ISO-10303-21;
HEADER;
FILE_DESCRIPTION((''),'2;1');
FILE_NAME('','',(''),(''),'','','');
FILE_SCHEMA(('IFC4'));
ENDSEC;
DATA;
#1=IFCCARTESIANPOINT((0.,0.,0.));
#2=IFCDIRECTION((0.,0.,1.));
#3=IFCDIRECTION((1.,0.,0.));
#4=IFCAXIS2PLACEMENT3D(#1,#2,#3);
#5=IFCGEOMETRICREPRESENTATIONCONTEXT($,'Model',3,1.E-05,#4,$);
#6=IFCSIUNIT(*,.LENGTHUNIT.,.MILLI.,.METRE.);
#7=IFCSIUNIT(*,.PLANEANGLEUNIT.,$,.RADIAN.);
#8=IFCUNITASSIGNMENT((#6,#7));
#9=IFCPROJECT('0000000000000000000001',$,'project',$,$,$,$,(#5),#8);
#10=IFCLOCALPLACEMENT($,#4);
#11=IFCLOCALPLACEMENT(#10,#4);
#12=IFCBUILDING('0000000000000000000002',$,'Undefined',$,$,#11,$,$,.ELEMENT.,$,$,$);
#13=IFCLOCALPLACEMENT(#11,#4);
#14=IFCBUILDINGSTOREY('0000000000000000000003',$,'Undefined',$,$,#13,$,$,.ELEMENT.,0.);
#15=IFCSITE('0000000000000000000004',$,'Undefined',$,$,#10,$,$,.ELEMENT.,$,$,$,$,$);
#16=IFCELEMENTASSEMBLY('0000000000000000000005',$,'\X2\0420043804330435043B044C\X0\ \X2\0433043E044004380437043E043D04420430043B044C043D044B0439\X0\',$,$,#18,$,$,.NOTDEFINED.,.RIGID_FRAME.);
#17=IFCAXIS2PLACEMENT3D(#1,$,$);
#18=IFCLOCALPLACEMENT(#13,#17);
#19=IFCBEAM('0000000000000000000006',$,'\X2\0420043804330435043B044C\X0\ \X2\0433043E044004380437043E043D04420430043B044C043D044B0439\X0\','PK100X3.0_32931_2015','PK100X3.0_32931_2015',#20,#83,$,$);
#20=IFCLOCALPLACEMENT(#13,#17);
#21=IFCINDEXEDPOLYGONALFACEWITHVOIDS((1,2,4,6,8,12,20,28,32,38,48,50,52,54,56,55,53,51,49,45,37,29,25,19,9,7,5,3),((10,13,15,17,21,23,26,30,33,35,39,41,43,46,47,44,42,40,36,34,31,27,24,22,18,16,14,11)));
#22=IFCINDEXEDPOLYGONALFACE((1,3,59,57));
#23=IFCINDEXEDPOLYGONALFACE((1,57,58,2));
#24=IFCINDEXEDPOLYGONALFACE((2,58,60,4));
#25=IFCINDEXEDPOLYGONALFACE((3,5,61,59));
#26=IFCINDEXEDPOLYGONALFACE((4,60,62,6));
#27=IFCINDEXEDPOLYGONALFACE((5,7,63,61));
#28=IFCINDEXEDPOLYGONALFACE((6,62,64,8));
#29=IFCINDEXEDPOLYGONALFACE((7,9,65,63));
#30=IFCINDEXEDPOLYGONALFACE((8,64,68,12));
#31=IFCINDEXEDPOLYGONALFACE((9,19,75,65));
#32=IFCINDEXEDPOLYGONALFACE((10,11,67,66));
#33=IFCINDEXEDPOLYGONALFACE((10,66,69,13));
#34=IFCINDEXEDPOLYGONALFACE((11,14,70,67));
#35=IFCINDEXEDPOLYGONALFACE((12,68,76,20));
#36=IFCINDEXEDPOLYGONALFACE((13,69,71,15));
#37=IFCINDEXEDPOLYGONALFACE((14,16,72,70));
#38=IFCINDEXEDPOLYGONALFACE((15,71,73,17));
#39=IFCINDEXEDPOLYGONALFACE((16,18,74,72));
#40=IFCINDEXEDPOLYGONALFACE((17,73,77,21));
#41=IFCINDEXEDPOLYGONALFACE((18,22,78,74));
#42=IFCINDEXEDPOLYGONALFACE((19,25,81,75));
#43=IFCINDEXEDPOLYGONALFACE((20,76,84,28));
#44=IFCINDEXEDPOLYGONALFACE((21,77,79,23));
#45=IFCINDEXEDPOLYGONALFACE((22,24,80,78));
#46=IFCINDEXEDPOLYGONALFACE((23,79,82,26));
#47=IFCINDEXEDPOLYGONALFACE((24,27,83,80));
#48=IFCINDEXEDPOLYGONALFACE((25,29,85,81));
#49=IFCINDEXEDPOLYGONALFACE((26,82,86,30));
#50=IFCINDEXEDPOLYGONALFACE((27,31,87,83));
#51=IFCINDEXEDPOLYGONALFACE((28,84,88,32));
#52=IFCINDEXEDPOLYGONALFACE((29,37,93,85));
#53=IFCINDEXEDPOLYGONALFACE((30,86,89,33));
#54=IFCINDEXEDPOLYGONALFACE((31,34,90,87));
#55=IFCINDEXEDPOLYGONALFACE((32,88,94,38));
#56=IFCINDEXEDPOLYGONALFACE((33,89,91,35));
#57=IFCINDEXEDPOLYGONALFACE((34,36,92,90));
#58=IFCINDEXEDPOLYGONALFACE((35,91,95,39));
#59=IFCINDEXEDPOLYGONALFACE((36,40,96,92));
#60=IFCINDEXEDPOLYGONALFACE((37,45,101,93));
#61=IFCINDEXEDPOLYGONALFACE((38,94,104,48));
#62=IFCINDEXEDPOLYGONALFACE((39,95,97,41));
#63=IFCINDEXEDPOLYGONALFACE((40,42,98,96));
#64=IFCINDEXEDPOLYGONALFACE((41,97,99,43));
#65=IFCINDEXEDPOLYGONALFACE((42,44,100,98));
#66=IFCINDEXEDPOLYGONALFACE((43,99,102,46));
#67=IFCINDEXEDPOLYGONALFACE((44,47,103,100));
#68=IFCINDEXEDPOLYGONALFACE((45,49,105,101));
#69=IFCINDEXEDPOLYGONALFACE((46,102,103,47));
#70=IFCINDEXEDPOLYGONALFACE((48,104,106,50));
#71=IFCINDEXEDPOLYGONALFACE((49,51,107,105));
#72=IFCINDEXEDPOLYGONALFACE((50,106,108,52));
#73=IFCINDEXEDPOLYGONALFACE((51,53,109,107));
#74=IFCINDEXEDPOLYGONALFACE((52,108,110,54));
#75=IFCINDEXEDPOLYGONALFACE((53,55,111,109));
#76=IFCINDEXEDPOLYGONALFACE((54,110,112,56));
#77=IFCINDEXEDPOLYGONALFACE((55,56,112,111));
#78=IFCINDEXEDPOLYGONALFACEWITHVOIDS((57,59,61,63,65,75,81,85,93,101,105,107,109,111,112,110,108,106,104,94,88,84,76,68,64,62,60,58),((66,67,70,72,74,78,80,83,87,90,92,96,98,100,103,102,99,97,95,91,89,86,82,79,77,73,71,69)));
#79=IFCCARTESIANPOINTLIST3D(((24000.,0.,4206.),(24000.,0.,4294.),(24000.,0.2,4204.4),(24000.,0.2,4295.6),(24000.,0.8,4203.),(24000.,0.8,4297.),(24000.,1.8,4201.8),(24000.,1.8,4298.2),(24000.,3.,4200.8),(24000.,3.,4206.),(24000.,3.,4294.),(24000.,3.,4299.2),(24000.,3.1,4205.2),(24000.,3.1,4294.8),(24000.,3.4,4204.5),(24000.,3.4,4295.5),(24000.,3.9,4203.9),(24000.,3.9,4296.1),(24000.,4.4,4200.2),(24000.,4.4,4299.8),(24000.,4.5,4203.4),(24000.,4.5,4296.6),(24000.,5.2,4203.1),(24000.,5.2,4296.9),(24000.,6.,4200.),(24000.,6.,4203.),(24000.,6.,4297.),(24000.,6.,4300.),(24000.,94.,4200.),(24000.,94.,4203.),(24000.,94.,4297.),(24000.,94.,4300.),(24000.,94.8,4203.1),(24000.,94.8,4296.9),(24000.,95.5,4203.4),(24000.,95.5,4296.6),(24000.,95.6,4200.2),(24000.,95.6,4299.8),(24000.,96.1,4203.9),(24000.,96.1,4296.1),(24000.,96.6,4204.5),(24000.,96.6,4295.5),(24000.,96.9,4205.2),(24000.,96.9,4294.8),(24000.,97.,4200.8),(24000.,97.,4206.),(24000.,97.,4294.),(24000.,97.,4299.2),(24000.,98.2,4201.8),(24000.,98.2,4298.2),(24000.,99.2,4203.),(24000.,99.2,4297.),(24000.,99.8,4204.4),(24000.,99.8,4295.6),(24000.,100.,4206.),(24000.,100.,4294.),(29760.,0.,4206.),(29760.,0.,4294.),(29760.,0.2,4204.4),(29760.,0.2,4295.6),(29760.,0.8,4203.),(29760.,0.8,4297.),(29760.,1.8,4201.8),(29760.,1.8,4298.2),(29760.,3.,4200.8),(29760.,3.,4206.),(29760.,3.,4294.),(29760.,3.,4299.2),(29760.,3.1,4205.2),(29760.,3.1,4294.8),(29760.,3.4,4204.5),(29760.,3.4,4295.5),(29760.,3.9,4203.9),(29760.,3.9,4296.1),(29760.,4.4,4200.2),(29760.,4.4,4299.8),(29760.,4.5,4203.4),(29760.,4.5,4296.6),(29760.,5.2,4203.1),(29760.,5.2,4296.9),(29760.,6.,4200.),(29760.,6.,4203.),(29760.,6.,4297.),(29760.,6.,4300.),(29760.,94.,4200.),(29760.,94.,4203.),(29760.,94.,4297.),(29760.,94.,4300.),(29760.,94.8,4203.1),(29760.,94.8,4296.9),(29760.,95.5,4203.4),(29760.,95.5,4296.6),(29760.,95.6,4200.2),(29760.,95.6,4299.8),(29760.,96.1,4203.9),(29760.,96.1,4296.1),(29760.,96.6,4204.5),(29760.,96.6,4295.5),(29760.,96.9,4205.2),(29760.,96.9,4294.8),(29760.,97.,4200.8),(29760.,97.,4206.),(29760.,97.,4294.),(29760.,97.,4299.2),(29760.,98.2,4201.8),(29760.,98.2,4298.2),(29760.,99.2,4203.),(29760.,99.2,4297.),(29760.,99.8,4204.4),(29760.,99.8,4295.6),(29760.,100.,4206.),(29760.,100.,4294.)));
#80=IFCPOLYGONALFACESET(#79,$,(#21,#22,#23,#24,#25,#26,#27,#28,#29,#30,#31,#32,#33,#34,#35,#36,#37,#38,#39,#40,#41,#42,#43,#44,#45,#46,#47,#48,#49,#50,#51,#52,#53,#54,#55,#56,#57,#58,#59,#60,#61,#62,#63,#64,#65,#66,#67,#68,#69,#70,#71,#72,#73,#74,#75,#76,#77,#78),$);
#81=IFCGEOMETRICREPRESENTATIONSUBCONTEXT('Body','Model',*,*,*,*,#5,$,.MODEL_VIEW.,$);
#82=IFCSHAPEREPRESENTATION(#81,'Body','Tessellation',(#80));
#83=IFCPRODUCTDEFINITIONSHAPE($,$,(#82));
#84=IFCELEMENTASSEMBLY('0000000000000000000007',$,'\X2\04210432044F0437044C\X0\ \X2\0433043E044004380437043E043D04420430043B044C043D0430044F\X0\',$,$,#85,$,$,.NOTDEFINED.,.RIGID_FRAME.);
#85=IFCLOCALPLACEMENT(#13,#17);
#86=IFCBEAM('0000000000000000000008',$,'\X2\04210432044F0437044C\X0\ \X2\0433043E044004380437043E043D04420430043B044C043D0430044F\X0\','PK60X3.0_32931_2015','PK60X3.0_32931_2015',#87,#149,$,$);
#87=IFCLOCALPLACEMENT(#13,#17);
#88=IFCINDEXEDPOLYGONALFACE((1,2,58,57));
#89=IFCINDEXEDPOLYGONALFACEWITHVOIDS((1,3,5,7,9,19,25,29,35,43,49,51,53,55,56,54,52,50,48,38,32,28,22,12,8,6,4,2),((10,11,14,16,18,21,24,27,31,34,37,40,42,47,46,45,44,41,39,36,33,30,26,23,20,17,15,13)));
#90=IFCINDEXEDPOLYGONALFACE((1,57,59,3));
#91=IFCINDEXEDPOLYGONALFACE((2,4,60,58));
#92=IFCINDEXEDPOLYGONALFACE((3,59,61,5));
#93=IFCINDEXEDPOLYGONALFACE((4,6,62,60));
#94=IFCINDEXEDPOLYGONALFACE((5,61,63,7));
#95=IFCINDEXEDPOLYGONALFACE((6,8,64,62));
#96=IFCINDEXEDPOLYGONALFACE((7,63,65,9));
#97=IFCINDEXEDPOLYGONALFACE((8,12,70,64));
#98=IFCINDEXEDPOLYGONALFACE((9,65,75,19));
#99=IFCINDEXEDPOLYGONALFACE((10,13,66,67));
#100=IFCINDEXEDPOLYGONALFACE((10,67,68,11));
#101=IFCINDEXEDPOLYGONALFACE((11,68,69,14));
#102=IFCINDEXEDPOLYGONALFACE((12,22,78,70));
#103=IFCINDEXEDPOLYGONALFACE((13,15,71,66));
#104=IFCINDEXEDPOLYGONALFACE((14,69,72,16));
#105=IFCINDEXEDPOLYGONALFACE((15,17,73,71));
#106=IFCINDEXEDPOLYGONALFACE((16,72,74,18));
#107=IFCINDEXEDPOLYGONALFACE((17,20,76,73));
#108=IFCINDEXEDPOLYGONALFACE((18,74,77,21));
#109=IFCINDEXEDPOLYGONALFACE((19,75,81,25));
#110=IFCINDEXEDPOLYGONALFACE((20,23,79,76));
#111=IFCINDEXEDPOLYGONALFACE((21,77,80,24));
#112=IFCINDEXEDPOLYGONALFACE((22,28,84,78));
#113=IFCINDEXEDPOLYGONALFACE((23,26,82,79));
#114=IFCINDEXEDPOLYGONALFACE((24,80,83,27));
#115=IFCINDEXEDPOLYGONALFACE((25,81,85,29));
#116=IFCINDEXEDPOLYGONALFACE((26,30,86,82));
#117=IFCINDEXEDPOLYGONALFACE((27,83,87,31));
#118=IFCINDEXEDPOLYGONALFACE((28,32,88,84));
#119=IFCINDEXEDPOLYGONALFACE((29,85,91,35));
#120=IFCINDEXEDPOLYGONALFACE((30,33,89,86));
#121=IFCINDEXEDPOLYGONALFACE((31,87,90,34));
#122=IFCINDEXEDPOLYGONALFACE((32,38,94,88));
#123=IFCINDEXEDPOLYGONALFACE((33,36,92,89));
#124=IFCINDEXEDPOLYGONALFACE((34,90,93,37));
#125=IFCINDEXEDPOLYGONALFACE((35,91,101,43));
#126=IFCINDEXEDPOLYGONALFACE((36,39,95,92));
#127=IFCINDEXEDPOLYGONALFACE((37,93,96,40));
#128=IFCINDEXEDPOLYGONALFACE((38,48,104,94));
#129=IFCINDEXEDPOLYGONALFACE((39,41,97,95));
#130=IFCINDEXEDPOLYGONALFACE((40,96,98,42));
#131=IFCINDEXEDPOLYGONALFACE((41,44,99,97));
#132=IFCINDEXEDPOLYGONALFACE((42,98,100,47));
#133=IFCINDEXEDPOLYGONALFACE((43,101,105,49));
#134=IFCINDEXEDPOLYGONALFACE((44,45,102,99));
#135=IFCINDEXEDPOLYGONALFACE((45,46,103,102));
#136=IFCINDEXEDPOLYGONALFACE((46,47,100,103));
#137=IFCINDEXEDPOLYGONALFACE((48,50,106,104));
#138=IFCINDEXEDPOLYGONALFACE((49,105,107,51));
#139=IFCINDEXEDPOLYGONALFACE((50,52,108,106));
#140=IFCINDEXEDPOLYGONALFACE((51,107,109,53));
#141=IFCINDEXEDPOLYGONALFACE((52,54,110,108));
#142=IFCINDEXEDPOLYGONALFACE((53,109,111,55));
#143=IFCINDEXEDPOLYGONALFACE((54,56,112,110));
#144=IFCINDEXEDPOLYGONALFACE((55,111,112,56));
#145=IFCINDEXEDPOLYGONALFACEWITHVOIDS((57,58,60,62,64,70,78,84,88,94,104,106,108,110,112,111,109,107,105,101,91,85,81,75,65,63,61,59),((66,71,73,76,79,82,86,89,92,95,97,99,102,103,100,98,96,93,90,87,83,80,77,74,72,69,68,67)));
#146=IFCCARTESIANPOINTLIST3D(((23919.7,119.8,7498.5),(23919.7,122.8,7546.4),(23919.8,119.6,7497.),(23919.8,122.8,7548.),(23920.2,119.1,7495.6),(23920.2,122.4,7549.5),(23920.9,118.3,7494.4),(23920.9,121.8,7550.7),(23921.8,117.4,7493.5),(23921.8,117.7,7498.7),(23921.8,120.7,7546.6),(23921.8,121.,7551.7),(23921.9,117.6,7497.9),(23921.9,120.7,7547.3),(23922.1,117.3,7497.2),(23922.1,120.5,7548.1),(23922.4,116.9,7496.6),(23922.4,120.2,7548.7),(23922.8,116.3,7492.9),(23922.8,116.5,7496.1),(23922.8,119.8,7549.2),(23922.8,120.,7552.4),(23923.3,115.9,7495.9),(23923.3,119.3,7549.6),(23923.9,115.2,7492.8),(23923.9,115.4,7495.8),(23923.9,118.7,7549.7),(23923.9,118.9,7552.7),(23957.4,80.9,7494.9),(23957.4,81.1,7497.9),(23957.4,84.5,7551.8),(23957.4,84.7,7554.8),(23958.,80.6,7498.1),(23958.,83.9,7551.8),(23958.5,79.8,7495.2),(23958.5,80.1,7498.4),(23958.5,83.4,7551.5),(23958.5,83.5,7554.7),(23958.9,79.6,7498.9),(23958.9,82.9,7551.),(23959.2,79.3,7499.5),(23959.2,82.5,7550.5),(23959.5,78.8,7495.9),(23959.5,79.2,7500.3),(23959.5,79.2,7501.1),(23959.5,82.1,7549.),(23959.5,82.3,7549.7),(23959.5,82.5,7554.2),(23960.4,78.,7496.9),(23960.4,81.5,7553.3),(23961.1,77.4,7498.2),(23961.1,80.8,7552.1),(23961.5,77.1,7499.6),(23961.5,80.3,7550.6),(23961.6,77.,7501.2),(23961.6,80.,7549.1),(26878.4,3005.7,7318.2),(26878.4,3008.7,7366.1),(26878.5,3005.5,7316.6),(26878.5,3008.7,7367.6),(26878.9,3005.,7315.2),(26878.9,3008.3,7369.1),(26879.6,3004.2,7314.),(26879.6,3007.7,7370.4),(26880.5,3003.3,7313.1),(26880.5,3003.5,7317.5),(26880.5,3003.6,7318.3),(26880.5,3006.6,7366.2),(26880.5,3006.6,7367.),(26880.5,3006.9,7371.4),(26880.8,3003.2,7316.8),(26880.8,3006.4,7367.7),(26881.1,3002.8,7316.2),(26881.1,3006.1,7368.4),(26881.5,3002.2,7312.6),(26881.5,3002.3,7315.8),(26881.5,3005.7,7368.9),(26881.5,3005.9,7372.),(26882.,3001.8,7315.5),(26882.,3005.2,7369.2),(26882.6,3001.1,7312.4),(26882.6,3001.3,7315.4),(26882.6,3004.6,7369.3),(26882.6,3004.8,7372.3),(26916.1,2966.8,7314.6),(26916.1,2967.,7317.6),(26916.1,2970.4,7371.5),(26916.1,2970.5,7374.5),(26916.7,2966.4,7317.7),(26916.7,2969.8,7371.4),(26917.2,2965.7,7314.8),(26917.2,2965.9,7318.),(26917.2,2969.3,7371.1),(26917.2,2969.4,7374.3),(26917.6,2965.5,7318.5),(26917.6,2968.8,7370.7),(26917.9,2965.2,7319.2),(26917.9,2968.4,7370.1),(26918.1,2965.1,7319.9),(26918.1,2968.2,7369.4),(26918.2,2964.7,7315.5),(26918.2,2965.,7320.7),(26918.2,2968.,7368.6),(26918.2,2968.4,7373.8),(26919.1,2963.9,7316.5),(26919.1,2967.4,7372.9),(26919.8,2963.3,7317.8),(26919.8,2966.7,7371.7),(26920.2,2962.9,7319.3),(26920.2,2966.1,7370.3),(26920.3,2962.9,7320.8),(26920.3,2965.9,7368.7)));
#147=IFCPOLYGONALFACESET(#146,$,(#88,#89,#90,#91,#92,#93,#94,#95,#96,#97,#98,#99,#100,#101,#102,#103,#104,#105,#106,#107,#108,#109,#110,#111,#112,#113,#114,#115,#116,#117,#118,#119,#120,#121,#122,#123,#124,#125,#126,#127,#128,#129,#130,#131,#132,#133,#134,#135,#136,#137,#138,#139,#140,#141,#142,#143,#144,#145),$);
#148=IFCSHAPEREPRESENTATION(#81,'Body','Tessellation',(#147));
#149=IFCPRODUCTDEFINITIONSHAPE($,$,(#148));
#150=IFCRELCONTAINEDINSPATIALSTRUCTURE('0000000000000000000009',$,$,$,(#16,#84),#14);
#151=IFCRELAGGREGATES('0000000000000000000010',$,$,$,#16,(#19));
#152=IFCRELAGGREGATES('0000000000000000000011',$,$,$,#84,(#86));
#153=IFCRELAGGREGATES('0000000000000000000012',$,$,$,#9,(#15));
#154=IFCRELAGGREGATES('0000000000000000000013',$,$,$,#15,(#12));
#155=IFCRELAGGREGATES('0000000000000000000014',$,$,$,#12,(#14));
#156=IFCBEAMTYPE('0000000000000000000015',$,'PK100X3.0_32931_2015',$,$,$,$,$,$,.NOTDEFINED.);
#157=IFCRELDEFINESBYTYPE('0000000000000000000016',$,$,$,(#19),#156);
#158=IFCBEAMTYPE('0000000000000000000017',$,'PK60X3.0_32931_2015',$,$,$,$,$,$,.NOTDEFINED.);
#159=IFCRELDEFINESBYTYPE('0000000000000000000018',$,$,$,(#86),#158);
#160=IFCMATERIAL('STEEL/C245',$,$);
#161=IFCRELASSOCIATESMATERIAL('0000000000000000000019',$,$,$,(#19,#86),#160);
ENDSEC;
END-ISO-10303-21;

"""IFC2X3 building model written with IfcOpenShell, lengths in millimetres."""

from ifc_helpers import new_model, si_unit, frame, origin_with_axes, origin_2d_with_axis, place, context, subcontext, project, spatial, hollow_rectangle, extrude, material, type_object, element, aggregate, save


model = new_model("IFC2X3")

# Units and contexts
model_context = context("Model", 3, precision=1e-05, world=origin_with_axes())
body_context = subcontext(model_context, "Body", "Model", "MODEL_VIEW")
ifc_project = project(units=[si_unit("LENGTHUNIT", "METRE", prefix="MILLI"), si_unit("PLANEANGLEUNIT", "RADIAN")], contexts=[model_context])

# Site, building, storey
site_placement = place(None, origin_with_axes())
site = spatial("IfcSite", under=ifc_project, at=site_placement, Name="Undefined", CompositionType="ELEMENT")
building_placement = place(site_placement, origin_with_axes())
building = spatial("IfcBuilding", under=site, at=building_placement, Name="Undefined", CompositionType="ELEMENT")
storey_placement = place(building_placement, origin_with_axes())
storey = spatial("IfcBuildingStorey", under=building, at=storey_placement, Name="Undefined", CompositionType="ELEMENT", Elevation=0.0)

# Shared definitions
ifc_material = material(Name="STEEL/C245")

# Element assemblies, beams
assembly_1_placement = place(storey_placement, origin_with_axes())
assembly_1 = element("IfcElementAssembly", 1, at=assembly_1_placement, inside=storey, Name="Ригель горизонтальный", AssemblyPlace="NOTDEFINED", PredefinedType="RIGID_FRAME")
beam_type_1 = type_object("IfcBeamType", Name="PK100X3.0_32931_2015", PredefinedType="NOTDEFINED")
beam_1_placement = place(assembly_1_placement, frame((29760.0, 50.0, 4250.0), z_axis=(0.0, 0.0, 1.0), x_axis=(-1.0, 0.0, 0.0)))
beam_1 = element("IfcBeam", 2, at=beam_1_placement, type_object=beam_type_1, material=ifc_material, Name="Ригель горизонтальный", Description="PK100X3.0_32931_2015", ObjectType="PK100X3.0_32931_2015", context=body_context, shape_type="SweptSolid", body=[
    extrude(hollow_rectangle(XDim=100.0, YDim=100.0, WallThickness=3.0, InnerFilletRadius=3.0, OuterFilletRadius=6.0, at=origin_2d_with_axis()), frame((5760.0, 0.0, 0.0), z_axis=(-1.0, 0.0, 0.0), x_axis=(0.0, -1.0, 0.0)), (0.0, 0.0, 1.0), 5760.0),
])
aggregate(assembly_1, [beam_1])
assembly_2_placement = place(storey_placement, origin_with_axes())
assembly_2 = element("IfcElementAssembly", 3, at=assembly_2_placement, inside=storey, Name="Связь горизонтальная", AssemblyPlace="NOTDEFINED", PredefinedType="RIGID_FRAME")
beam_type_2 = type_object("IfcBeamType", Name="PK60X3.0_32931_2015", PredefinedType="NOTDEFINED")
beam_2_placement = place(assembly_2_placement, frame((23940.7, 99.9, 7523.8), z_axis=(0.0, 0.062378, 0.998053), x_axis=(0.715179, 0.69758, -0.043599)))
beam_2 = element("IfcBeam", 4, at=beam_2_placement, type_object=beam_type_2, material=ifc_material, Name="Связь горизонтальная", Description="PK60X3.0_32931_2015", ObjectType="PK60X3.0_32931_2015", context=body_context, shape_type="SweptSolid", body=[
    extrude(hollow_rectangle(XDim=60.0, YDim=60.0, WallThickness=3.0, InnerFilletRadius=3.0, OuterFilletRadius=6.0, at=origin_2d_with_axis()), frame((4137.0, 0.0, 0.0), z_axis=(-1.0, 0.0, 0.0), x_axis=(0.0, -1.0, 0.0)), (0.0, 0.0, 1.0), 4137.0),
])
aggregate(assembly_2, [beam_2])

save(model, "model.ifc")
